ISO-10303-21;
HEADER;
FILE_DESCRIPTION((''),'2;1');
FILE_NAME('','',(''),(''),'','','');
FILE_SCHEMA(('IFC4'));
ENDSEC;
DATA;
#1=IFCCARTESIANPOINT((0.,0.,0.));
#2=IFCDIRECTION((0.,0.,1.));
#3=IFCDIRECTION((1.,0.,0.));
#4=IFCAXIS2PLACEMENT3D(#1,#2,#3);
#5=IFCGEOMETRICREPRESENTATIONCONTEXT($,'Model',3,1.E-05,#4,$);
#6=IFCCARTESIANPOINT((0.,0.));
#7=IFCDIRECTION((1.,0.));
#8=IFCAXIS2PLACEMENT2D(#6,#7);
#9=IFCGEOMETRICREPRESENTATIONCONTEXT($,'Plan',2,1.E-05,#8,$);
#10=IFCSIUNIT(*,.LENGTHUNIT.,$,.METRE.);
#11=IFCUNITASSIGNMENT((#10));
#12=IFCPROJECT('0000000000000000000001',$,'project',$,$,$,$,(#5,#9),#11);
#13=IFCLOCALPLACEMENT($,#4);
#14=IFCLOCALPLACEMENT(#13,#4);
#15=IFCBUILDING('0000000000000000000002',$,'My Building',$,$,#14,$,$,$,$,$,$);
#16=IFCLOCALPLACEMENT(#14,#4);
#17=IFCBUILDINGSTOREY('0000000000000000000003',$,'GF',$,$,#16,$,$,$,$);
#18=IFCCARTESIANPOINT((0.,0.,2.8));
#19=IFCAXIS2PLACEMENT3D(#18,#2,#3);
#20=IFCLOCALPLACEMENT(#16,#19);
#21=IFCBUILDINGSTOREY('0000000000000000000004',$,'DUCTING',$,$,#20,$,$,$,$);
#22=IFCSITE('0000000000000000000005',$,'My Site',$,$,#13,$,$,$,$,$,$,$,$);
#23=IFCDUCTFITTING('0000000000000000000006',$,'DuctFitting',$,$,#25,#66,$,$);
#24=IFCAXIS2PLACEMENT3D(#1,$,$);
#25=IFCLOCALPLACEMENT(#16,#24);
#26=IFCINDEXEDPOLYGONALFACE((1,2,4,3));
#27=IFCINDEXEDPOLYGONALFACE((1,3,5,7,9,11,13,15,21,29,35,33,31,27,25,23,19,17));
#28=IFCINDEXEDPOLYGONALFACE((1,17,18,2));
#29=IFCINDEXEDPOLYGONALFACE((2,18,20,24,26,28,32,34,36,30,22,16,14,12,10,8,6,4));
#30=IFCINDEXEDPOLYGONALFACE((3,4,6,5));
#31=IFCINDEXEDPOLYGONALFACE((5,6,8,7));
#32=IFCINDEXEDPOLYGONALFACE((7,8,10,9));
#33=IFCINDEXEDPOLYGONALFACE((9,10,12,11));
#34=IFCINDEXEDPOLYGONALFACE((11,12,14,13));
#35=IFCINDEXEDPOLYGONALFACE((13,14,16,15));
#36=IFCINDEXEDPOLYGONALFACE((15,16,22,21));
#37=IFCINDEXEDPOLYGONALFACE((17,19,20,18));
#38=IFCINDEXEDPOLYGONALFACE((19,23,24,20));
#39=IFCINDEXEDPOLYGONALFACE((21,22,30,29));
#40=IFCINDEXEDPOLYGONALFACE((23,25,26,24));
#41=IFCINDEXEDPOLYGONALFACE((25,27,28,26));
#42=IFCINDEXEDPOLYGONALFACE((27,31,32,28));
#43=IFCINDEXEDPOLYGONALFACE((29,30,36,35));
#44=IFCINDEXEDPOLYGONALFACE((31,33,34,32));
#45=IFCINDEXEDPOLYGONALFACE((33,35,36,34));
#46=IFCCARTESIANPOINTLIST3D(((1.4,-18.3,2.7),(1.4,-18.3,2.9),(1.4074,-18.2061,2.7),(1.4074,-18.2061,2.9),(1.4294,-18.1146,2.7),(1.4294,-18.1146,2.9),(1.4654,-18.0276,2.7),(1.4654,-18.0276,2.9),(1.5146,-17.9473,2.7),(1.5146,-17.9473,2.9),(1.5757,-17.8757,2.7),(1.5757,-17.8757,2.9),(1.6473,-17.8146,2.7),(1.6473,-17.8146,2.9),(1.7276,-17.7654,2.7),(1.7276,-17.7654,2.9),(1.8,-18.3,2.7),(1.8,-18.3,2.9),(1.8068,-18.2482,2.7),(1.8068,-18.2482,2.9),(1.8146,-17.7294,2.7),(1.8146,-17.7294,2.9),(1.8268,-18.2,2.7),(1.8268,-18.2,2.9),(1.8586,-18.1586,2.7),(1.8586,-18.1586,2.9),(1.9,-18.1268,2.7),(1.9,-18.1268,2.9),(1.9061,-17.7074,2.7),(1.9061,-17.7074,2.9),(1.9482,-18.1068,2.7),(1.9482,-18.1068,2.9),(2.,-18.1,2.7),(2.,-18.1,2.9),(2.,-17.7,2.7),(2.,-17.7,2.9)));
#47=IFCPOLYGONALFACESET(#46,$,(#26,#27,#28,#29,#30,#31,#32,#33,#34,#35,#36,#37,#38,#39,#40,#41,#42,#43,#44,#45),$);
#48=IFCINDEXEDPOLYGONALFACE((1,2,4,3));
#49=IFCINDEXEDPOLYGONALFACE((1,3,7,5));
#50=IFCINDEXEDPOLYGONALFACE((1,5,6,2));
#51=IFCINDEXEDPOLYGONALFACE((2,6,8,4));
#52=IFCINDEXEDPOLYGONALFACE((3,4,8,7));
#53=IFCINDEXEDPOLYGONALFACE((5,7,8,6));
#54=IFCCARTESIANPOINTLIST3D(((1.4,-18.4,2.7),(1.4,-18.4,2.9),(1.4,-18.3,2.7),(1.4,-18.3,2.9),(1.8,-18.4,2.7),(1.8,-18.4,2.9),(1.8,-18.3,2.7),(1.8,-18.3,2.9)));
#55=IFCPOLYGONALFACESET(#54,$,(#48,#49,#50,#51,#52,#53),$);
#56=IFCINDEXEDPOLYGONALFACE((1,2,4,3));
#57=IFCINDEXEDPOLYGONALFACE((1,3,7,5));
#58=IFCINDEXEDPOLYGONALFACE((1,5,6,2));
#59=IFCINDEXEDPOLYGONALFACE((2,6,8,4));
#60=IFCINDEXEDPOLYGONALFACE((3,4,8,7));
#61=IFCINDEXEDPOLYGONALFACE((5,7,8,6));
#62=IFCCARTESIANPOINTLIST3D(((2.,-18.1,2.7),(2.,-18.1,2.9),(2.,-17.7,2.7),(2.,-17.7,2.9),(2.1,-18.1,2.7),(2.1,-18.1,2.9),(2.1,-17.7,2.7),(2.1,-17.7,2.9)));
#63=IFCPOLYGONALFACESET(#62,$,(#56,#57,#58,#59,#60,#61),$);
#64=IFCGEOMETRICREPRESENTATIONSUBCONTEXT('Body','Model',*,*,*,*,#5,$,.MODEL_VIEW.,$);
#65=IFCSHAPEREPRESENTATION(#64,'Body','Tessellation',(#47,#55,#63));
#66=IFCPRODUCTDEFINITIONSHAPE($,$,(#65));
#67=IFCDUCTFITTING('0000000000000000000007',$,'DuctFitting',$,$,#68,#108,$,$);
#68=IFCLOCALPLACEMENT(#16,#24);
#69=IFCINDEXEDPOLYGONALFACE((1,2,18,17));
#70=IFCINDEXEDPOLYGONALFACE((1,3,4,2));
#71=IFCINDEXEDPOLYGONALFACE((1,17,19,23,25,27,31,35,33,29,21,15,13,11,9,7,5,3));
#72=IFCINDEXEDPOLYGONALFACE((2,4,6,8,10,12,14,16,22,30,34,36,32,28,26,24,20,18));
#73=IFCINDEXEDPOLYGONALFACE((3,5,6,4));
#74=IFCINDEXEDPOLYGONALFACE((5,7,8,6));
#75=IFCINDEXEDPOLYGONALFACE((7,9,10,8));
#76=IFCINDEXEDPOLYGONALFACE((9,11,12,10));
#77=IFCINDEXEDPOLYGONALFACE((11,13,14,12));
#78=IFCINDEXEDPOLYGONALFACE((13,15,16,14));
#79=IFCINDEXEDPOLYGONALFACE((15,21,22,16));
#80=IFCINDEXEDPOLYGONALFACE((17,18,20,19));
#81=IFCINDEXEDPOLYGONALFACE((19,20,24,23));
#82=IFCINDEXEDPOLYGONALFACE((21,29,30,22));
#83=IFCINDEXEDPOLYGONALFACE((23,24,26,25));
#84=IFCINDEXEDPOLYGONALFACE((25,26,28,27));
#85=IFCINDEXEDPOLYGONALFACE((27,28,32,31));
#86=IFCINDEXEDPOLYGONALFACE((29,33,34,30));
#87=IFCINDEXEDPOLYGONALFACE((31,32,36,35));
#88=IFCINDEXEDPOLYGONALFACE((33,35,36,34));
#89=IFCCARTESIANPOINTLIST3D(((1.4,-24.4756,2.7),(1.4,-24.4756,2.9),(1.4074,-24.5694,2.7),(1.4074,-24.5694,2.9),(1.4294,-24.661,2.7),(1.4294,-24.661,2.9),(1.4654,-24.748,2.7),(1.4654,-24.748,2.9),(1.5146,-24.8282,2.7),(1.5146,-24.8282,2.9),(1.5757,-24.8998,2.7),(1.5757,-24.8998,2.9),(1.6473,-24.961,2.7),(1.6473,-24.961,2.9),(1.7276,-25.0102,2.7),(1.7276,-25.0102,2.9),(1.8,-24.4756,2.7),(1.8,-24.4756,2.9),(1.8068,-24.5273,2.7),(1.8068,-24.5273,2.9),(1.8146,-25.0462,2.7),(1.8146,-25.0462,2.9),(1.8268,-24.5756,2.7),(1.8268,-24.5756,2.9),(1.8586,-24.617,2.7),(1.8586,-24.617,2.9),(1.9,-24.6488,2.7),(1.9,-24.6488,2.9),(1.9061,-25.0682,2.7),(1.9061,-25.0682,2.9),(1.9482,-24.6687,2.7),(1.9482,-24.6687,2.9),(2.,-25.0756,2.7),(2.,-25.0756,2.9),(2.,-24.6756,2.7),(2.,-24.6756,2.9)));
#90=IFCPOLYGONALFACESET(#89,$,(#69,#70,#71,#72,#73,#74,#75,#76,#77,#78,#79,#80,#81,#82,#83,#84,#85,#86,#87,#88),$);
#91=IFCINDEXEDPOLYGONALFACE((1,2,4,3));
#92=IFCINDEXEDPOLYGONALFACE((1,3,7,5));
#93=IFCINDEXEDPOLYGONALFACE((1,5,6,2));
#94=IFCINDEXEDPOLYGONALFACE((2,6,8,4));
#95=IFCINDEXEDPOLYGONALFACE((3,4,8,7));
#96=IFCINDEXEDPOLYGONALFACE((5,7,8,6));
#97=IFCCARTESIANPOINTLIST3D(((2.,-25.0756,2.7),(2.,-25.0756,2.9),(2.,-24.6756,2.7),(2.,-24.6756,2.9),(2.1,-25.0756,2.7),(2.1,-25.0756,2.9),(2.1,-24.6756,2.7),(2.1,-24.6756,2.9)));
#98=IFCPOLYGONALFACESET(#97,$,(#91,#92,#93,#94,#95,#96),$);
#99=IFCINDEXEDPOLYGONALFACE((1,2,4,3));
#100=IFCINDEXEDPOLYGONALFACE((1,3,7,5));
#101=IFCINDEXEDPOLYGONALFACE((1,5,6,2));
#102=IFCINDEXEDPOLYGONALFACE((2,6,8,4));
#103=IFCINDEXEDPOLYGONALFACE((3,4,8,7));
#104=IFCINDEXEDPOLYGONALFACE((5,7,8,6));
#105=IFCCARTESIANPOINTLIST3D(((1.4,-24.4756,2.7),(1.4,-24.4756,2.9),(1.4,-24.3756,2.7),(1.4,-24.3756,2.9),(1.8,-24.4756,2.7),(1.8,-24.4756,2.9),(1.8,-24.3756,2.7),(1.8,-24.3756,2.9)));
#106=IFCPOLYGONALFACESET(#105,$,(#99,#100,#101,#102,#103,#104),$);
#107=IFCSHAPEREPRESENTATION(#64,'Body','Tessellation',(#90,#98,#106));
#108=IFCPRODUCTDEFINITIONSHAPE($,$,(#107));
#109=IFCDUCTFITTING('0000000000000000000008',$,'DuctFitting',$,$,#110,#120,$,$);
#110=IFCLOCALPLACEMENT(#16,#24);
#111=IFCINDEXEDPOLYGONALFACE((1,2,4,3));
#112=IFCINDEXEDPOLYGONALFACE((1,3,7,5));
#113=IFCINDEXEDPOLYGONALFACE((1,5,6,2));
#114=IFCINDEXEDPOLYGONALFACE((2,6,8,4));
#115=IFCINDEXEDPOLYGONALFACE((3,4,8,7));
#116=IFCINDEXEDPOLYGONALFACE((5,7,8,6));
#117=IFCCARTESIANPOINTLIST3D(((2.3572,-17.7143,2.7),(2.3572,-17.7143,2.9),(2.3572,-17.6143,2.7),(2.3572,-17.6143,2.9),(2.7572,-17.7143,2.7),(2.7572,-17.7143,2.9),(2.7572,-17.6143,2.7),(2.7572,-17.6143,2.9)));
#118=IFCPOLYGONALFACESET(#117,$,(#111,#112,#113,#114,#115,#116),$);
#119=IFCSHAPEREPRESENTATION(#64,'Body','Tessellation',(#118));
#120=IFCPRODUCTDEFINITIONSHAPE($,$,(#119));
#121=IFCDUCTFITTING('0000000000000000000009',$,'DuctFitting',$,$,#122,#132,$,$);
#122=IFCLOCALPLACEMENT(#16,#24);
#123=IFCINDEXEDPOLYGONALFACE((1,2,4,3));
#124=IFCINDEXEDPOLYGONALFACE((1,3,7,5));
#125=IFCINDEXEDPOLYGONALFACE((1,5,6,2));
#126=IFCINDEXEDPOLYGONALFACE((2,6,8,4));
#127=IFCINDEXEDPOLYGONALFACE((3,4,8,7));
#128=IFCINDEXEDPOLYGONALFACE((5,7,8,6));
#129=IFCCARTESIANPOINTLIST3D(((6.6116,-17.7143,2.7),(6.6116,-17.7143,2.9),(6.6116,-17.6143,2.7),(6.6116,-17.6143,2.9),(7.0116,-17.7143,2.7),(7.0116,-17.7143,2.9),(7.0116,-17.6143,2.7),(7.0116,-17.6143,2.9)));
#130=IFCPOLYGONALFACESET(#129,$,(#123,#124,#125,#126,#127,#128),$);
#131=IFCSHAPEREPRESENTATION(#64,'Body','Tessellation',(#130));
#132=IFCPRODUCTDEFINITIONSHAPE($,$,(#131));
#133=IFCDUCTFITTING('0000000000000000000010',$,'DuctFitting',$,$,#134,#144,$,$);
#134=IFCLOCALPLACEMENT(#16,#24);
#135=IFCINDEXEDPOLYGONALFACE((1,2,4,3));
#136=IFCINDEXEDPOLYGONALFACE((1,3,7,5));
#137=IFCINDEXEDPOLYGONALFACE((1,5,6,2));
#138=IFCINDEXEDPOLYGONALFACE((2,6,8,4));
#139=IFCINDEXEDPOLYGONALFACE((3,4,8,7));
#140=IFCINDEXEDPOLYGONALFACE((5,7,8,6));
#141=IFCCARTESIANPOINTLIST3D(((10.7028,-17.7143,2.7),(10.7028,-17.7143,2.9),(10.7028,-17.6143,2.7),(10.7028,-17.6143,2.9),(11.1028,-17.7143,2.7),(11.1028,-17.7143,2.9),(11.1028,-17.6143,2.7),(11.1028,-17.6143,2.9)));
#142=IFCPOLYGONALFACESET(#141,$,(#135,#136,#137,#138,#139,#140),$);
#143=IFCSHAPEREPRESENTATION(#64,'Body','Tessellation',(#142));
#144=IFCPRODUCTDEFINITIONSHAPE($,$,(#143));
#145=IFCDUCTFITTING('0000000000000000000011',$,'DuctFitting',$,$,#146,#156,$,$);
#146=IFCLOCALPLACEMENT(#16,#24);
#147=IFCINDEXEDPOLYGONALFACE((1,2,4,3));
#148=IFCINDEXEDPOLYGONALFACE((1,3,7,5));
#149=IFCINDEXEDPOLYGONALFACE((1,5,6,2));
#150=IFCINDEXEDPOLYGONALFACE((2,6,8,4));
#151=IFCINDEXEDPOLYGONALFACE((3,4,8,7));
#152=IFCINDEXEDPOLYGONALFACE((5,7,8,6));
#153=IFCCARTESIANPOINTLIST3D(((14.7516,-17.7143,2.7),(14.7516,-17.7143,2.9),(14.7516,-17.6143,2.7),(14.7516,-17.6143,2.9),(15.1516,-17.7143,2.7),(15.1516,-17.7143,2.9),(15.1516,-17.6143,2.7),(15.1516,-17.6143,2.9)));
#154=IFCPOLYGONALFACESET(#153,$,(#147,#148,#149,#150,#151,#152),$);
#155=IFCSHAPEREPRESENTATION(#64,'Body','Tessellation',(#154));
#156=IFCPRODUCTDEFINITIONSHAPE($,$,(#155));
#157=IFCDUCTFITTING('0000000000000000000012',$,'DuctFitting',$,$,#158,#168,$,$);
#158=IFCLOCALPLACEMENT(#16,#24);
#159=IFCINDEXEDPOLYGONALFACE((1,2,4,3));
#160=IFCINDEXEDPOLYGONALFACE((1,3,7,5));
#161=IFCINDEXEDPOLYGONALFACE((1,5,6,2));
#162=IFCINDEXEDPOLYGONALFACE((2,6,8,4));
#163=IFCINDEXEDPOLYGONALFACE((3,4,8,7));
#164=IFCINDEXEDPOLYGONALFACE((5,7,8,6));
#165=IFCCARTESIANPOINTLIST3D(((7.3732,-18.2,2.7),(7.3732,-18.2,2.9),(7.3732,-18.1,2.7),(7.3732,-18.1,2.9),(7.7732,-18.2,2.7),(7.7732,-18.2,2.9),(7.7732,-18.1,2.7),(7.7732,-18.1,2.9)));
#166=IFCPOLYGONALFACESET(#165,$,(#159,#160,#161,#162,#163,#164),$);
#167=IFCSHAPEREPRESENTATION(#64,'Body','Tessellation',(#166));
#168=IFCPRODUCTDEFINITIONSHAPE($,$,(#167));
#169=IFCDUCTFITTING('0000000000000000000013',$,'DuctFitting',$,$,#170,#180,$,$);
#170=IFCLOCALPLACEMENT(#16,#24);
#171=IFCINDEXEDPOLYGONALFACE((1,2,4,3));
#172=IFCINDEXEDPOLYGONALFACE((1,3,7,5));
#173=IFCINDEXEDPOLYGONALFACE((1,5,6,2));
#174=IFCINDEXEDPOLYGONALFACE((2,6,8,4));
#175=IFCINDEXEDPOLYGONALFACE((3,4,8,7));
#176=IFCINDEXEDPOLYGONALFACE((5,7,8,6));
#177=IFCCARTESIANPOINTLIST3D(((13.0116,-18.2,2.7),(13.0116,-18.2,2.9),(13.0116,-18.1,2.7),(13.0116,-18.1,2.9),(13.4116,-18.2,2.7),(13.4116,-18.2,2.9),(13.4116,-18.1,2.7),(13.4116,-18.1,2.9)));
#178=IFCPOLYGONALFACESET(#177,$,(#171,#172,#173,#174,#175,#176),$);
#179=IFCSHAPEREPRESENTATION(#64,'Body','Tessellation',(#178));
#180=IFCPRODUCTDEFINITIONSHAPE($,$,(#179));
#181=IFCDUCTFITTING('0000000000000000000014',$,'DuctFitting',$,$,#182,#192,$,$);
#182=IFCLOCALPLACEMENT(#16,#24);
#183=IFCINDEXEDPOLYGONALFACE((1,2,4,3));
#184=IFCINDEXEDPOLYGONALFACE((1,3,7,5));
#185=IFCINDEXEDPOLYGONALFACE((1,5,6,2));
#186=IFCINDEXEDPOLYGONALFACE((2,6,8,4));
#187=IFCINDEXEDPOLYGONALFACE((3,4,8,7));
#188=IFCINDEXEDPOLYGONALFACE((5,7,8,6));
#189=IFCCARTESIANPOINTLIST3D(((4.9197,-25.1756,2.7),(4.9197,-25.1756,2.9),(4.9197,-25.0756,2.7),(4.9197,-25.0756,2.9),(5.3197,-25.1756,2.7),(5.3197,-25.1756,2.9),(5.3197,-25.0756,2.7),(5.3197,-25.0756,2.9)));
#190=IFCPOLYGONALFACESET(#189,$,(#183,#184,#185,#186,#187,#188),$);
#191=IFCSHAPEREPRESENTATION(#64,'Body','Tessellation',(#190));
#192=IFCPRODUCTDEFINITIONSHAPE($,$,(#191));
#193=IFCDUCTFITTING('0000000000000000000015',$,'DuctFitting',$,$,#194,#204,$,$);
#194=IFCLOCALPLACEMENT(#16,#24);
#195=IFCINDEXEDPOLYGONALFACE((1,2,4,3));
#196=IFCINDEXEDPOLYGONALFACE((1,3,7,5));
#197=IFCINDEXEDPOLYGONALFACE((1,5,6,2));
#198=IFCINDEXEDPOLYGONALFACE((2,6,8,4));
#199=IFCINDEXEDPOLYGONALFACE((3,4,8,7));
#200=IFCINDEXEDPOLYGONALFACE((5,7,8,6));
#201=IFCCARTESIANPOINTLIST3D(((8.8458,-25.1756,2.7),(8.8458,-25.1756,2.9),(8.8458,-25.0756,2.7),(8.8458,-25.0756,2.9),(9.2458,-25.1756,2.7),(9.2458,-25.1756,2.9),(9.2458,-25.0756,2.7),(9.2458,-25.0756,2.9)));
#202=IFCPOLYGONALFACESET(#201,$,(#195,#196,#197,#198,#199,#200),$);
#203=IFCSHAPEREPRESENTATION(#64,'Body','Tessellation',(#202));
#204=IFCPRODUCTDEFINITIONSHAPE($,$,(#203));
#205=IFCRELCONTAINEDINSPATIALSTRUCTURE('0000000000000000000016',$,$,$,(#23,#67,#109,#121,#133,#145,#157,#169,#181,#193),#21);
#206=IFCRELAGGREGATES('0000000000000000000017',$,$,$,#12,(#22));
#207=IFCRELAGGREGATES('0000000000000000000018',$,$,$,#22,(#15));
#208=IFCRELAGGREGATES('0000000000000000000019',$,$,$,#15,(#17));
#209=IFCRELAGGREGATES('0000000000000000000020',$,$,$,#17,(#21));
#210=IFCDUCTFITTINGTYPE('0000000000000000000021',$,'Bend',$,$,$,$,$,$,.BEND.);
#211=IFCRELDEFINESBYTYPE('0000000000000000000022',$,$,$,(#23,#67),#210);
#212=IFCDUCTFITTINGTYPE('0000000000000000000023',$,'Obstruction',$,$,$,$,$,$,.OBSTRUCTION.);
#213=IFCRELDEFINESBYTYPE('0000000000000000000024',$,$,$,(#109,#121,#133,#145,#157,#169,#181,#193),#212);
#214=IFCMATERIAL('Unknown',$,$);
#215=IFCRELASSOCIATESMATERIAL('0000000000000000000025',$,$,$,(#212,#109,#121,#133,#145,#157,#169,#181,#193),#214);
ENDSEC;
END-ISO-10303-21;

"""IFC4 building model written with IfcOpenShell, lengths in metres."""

from ifc_helpers import new_model, si_unit, frame, origin_with_axes, origin_2d_with_axis, place, context, subcontext, project, spatial, line, arc, indexed_curve, rectangle, outline, extrude, source, transform, mapped, material, material_profile, profile_set, profile_usage, type_object, type_shapes, element, save


model = new_model("IFC4")

# Units and contexts
model_context = context("Model", 3, precision=1e-05, world=origin_with_axes())
plan_context = context("Plan", 2, precision=1e-05, world=origin_2d_with_axis())
body_context = subcontext(model_context, "Body", "Model", "MODEL_VIEW")
ifc_project = project(units=[si_unit("LENGTHUNIT", "METRE")], contexts=[model_context, plan_context])

# Site, building, storeys
site_placement = place(None, origin_with_axes())
site = spatial("IfcSite", under=ifc_project, at=site_placement, Name="My Site")
building_placement = place(site_placement, origin_with_axes())
building = spatial("IfcBuilding", under=site, at=building_placement, Name="My Building")
storey_1_placement = place(building_placement, origin_with_axes())
storey_1 = spatial("IfcBuildingStorey", under=building, at=storey_1_placement, Name="GF")
storey_2_placement = place(storey_1_placement, frame((0.0, 0.0, 2.8), z_axis=(0.0, 0.0, 1.0), x_axis=(1.0, 0.0, 0.0)))
storey_2 = spatial("IfcBuildingStorey", under=storey_1, at=storey_2_placement, Name="DUCTING")

# Shared definitions
ifc_material = material(Name="Unknown")

# Duct fittings
duct_fitting_type_1 = type_object("IfcDuctFittingType", Name="Bend", PredefinedType="BEND")
shared_shape = source(origin_with_axes(), body_context, "Body", "SweptSolid", [
    extrude(outline(indexed_curve([(0.2, 0.0), (0.2586, -0.1414), (0.4, -0.2), (0.4, -0.6), (-0.0243, -0.4243), (-0.2, 0.0)], segments=[arc(1, 2, 3), line(3, 4), arc(4, 5, 6), line(6, 1)])), frame((0.0, -0.1, -0.1), z_axis=(0.0, -1.0, 0.0), x_axis=(1.0, 0.0, 0.0)), (0.0, 0.0, -1.0), 0.2),
    extrude(rectangle(XDim=0.4, YDim=0.2), origin_with_axes(), (0.0, 0.0, -1.0), 0.1),
    extrude(rectangle(XDim=0.4, YDim=0.2), frame((0.4, 0.0, -0.5), z_axis=(1.0, 0.0, 0.0), x_axis=(0.0, 0.0, 1.0)), (0.0, 0.0, 1.0), 0.1),
])
type_shapes(duct_fitting_type_1, [shared_shape])
for number, where, z_axis, x_axis, name in (
    (1, (1.6, -18.4, 0.0), (0.0, -1.0, 0.0), (1.0, 0.0, 0.0), "DuctFitting"),
    (2, (2.1, -24.8756, 0.0), (1.0, 0.0, 0.0), (0.0, 1.0, 0.0), "DuctFitting"),
):
    element("IfcDuctFitting", number, at=place(storey_2_placement, frame(where, z_axis=z_axis, x_axis=x_axis)), inside=storey_2, type_object=duct_fitting_type_1, Name=name, context=body_context, shape_type="MappedRepresentation", body=[
        mapped(shared_shape, transform((0.0, 0.0, 0.0), x_axis=(1.0, 0.0, 0.0), y_axis=(0.0, 1.0, 0.0), z_axis=(0.0, 0.0, 1.0), scale=1.0)),
    ])
ifc_material_profile_1 = material_profile(ifc_material, rectangle(XDim=0.4, YDim=0.2))
ifc_profile_set_1 = profile_set([ifc_material_profile_1])
ifc_profile_usage_1 = profile_usage(ifc_profile_set_1, cardinal=5)
duct_fitting_type_2 = type_object("IfcDuctFittingType", Name="Obstruction", PredefinedType="OBSTRUCTION", material=ifc_profile_set_1)
duct_fitting_1_placement = place(storey_2_placement, frame((2.5572, -17.7143, 0.0), z_axis=(0.0, 1.0, 0.0), x_axis=(-1.0, 0.0, 0.0)))
element("IfcDuctFitting", 3, at=duct_fitting_1_placement, inside=storey_2, type_object=duct_fitting_type_2, material=ifc_profile_usage_1, Name="DuctFitting", context=body_context, shape_type="SweptSolid", body=[
    extrude(rectangle(XDim=0.4, YDim=0.2), origin_with_axes(), (0.0, 0.0, 1.0), 0.1),
])
ifc_profile_usage_2 = profile_usage(ifc_profile_set_1, cardinal=5)
duct_fitting_2_placement = place(storey_2_placement, frame((6.8116, -17.7143, 0.0), z_axis=(0.0, 1.0, 0.0), x_axis=(-1.0, 0.0, 0.0)))
element("IfcDuctFitting", 4, at=duct_fitting_2_placement, inside=storey_2, type_object=duct_fitting_type_2, material=ifc_profile_usage_2, Name="DuctFitting", context=body_context, shape_type="SweptSolid", body=[
    extrude(rectangle(XDim=0.4, YDim=0.2), origin_with_axes(), (0.0, 0.0, 1.0), 0.1),
])
ifc_profile_usage_3 = profile_usage(ifc_profile_set_1, cardinal=5)
duct_fitting_3_placement = place(storey_2_placement, frame((10.9028, -17.7143, 0.0), z_axis=(0.0, 1.0, 0.0), x_axis=(-1.0, 0.0, 0.0)))
element("IfcDuctFitting", 5, at=duct_fitting_3_placement, inside=storey_2, type_object=duct_fitting_type_2, material=ifc_profile_usage_3, Name="DuctFitting", context=body_context, shape_type="SweptSolid", body=[
    extrude(rectangle(XDim=0.4, YDim=0.2), origin_with_axes(), (0.0, 0.0, 1.0), 0.1),
])
ifc_profile_usage_4 = profile_usage(ifc_profile_set_1, cardinal=5)
duct_fitting_4_placement = place(storey_2_placement, frame((14.9516, -17.7143, 0.0), z_axis=(0.0, 1.0, 0.0), x_axis=(-1.0, 0.0, 0.0)))
element("IfcDuctFitting", 6, at=duct_fitting_4_placement, inside=storey_2, type_object=duct_fitting_type_2, material=ifc_profile_usage_4, Name="DuctFitting", context=body_context, shape_type="SweptSolid", body=[
    extrude(rectangle(XDim=0.4, YDim=0.2), origin_with_axes(), (0.0, 0.0, 1.0), 0.1),
])
ifc_profile_usage_5 = profile_usage(ifc_profile_set_1, cardinal=5)
duct_fitting_5_placement = place(storey_2_placement, frame((7.5732, -18.2, 0.0), z_axis=(0.0, 1.0, 0.0), x_axis=(-1.0, 0.0, 0.0)))
element("IfcDuctFitting", 7, at=duct_fitting_5_placement, inside=storey_2, type_object=duct_fitting_type_2, material=ifc_profile_usage_5, Name="DuctFitting", context=body_context, shape_type="SweptSolid", body=[
    extrude(rectangle(XDim=0.4, YDim=0.2), origin_with_axes(), (0.0, 0.0, 1.0), 0.1),
])
ifc_profile_usage_6 = profile_usage(ifc_profile_set_1, cardinal=5)
duct_fitting_6_placement = place(storey_2_placement, frame((13.2116, -18.2, 0.0), z_axis=(0.0, 1.0, 0.0), x_axis=(-1.0, 0.0, 0.0)))
element("IfcDuctFitting", 8, at=duct_fitting_6_placement, inside=storey_2, type_object=duct_fitting_type_2, material=ifc_profile_usage_6, Name="DuctFitting", context=body_context, shape_type="SweptSolid", body=[
    extrude(rectangle(XDim=0.4, YDim=0.2), origin_with_axes(), (0.0, 0.0, 1.0), 0.1),
])
ifc_profile_usage_7 = profile_usage(ifc_profile_set_1, cardinal=5)
duct_fitting_7_placement = place(storey_2_placement, frame((5.1197, -25.1756, 0.0), z_axis=(0.0, 1.0, 0.0), x_axis=(-1.0, 0.0, 0.0)))
element("IfcDuctFitting", 9, at=duct_fitting_7_placement, inside=storey_2, type_object=duct_fitting_type_2, material=ifc_profile_usage_7, Name="DuctFitting", context=body_context, shape_type="SweptSolid", body=[
    extrude(rectangle(XDim=0.4, YDim=0.2), origin_with_axes(), (0.0, 0.0, 1.0), 0.1),
])
ifc_profile_usage_8 = profile_usage(ifc_profile_set_1, cardinal=5)
duct_fitting_8_placement = place(storey_2_placement, frame((9.0458, -25.1756, 0.0), z_axis=(0.0, 1.0, 0.0), x_axis=(-1.0, 0.0, 0.0)))
element("IfcDuctFitting", 10, at=duct_fitting_8_placement, inside=storey_2, type_object=duct_fitting_type_2, material=ifc_profile_usage_8, Name="DuctFitting", context=body_context, shape_type="SweptSolid", body=[
    extrude(rectangle(XDim=0.4, YDim=0.2), origin_with_axes(), (0.0, 0.0, 1.0), 0.1),
])

save(model, "model.ifc")
